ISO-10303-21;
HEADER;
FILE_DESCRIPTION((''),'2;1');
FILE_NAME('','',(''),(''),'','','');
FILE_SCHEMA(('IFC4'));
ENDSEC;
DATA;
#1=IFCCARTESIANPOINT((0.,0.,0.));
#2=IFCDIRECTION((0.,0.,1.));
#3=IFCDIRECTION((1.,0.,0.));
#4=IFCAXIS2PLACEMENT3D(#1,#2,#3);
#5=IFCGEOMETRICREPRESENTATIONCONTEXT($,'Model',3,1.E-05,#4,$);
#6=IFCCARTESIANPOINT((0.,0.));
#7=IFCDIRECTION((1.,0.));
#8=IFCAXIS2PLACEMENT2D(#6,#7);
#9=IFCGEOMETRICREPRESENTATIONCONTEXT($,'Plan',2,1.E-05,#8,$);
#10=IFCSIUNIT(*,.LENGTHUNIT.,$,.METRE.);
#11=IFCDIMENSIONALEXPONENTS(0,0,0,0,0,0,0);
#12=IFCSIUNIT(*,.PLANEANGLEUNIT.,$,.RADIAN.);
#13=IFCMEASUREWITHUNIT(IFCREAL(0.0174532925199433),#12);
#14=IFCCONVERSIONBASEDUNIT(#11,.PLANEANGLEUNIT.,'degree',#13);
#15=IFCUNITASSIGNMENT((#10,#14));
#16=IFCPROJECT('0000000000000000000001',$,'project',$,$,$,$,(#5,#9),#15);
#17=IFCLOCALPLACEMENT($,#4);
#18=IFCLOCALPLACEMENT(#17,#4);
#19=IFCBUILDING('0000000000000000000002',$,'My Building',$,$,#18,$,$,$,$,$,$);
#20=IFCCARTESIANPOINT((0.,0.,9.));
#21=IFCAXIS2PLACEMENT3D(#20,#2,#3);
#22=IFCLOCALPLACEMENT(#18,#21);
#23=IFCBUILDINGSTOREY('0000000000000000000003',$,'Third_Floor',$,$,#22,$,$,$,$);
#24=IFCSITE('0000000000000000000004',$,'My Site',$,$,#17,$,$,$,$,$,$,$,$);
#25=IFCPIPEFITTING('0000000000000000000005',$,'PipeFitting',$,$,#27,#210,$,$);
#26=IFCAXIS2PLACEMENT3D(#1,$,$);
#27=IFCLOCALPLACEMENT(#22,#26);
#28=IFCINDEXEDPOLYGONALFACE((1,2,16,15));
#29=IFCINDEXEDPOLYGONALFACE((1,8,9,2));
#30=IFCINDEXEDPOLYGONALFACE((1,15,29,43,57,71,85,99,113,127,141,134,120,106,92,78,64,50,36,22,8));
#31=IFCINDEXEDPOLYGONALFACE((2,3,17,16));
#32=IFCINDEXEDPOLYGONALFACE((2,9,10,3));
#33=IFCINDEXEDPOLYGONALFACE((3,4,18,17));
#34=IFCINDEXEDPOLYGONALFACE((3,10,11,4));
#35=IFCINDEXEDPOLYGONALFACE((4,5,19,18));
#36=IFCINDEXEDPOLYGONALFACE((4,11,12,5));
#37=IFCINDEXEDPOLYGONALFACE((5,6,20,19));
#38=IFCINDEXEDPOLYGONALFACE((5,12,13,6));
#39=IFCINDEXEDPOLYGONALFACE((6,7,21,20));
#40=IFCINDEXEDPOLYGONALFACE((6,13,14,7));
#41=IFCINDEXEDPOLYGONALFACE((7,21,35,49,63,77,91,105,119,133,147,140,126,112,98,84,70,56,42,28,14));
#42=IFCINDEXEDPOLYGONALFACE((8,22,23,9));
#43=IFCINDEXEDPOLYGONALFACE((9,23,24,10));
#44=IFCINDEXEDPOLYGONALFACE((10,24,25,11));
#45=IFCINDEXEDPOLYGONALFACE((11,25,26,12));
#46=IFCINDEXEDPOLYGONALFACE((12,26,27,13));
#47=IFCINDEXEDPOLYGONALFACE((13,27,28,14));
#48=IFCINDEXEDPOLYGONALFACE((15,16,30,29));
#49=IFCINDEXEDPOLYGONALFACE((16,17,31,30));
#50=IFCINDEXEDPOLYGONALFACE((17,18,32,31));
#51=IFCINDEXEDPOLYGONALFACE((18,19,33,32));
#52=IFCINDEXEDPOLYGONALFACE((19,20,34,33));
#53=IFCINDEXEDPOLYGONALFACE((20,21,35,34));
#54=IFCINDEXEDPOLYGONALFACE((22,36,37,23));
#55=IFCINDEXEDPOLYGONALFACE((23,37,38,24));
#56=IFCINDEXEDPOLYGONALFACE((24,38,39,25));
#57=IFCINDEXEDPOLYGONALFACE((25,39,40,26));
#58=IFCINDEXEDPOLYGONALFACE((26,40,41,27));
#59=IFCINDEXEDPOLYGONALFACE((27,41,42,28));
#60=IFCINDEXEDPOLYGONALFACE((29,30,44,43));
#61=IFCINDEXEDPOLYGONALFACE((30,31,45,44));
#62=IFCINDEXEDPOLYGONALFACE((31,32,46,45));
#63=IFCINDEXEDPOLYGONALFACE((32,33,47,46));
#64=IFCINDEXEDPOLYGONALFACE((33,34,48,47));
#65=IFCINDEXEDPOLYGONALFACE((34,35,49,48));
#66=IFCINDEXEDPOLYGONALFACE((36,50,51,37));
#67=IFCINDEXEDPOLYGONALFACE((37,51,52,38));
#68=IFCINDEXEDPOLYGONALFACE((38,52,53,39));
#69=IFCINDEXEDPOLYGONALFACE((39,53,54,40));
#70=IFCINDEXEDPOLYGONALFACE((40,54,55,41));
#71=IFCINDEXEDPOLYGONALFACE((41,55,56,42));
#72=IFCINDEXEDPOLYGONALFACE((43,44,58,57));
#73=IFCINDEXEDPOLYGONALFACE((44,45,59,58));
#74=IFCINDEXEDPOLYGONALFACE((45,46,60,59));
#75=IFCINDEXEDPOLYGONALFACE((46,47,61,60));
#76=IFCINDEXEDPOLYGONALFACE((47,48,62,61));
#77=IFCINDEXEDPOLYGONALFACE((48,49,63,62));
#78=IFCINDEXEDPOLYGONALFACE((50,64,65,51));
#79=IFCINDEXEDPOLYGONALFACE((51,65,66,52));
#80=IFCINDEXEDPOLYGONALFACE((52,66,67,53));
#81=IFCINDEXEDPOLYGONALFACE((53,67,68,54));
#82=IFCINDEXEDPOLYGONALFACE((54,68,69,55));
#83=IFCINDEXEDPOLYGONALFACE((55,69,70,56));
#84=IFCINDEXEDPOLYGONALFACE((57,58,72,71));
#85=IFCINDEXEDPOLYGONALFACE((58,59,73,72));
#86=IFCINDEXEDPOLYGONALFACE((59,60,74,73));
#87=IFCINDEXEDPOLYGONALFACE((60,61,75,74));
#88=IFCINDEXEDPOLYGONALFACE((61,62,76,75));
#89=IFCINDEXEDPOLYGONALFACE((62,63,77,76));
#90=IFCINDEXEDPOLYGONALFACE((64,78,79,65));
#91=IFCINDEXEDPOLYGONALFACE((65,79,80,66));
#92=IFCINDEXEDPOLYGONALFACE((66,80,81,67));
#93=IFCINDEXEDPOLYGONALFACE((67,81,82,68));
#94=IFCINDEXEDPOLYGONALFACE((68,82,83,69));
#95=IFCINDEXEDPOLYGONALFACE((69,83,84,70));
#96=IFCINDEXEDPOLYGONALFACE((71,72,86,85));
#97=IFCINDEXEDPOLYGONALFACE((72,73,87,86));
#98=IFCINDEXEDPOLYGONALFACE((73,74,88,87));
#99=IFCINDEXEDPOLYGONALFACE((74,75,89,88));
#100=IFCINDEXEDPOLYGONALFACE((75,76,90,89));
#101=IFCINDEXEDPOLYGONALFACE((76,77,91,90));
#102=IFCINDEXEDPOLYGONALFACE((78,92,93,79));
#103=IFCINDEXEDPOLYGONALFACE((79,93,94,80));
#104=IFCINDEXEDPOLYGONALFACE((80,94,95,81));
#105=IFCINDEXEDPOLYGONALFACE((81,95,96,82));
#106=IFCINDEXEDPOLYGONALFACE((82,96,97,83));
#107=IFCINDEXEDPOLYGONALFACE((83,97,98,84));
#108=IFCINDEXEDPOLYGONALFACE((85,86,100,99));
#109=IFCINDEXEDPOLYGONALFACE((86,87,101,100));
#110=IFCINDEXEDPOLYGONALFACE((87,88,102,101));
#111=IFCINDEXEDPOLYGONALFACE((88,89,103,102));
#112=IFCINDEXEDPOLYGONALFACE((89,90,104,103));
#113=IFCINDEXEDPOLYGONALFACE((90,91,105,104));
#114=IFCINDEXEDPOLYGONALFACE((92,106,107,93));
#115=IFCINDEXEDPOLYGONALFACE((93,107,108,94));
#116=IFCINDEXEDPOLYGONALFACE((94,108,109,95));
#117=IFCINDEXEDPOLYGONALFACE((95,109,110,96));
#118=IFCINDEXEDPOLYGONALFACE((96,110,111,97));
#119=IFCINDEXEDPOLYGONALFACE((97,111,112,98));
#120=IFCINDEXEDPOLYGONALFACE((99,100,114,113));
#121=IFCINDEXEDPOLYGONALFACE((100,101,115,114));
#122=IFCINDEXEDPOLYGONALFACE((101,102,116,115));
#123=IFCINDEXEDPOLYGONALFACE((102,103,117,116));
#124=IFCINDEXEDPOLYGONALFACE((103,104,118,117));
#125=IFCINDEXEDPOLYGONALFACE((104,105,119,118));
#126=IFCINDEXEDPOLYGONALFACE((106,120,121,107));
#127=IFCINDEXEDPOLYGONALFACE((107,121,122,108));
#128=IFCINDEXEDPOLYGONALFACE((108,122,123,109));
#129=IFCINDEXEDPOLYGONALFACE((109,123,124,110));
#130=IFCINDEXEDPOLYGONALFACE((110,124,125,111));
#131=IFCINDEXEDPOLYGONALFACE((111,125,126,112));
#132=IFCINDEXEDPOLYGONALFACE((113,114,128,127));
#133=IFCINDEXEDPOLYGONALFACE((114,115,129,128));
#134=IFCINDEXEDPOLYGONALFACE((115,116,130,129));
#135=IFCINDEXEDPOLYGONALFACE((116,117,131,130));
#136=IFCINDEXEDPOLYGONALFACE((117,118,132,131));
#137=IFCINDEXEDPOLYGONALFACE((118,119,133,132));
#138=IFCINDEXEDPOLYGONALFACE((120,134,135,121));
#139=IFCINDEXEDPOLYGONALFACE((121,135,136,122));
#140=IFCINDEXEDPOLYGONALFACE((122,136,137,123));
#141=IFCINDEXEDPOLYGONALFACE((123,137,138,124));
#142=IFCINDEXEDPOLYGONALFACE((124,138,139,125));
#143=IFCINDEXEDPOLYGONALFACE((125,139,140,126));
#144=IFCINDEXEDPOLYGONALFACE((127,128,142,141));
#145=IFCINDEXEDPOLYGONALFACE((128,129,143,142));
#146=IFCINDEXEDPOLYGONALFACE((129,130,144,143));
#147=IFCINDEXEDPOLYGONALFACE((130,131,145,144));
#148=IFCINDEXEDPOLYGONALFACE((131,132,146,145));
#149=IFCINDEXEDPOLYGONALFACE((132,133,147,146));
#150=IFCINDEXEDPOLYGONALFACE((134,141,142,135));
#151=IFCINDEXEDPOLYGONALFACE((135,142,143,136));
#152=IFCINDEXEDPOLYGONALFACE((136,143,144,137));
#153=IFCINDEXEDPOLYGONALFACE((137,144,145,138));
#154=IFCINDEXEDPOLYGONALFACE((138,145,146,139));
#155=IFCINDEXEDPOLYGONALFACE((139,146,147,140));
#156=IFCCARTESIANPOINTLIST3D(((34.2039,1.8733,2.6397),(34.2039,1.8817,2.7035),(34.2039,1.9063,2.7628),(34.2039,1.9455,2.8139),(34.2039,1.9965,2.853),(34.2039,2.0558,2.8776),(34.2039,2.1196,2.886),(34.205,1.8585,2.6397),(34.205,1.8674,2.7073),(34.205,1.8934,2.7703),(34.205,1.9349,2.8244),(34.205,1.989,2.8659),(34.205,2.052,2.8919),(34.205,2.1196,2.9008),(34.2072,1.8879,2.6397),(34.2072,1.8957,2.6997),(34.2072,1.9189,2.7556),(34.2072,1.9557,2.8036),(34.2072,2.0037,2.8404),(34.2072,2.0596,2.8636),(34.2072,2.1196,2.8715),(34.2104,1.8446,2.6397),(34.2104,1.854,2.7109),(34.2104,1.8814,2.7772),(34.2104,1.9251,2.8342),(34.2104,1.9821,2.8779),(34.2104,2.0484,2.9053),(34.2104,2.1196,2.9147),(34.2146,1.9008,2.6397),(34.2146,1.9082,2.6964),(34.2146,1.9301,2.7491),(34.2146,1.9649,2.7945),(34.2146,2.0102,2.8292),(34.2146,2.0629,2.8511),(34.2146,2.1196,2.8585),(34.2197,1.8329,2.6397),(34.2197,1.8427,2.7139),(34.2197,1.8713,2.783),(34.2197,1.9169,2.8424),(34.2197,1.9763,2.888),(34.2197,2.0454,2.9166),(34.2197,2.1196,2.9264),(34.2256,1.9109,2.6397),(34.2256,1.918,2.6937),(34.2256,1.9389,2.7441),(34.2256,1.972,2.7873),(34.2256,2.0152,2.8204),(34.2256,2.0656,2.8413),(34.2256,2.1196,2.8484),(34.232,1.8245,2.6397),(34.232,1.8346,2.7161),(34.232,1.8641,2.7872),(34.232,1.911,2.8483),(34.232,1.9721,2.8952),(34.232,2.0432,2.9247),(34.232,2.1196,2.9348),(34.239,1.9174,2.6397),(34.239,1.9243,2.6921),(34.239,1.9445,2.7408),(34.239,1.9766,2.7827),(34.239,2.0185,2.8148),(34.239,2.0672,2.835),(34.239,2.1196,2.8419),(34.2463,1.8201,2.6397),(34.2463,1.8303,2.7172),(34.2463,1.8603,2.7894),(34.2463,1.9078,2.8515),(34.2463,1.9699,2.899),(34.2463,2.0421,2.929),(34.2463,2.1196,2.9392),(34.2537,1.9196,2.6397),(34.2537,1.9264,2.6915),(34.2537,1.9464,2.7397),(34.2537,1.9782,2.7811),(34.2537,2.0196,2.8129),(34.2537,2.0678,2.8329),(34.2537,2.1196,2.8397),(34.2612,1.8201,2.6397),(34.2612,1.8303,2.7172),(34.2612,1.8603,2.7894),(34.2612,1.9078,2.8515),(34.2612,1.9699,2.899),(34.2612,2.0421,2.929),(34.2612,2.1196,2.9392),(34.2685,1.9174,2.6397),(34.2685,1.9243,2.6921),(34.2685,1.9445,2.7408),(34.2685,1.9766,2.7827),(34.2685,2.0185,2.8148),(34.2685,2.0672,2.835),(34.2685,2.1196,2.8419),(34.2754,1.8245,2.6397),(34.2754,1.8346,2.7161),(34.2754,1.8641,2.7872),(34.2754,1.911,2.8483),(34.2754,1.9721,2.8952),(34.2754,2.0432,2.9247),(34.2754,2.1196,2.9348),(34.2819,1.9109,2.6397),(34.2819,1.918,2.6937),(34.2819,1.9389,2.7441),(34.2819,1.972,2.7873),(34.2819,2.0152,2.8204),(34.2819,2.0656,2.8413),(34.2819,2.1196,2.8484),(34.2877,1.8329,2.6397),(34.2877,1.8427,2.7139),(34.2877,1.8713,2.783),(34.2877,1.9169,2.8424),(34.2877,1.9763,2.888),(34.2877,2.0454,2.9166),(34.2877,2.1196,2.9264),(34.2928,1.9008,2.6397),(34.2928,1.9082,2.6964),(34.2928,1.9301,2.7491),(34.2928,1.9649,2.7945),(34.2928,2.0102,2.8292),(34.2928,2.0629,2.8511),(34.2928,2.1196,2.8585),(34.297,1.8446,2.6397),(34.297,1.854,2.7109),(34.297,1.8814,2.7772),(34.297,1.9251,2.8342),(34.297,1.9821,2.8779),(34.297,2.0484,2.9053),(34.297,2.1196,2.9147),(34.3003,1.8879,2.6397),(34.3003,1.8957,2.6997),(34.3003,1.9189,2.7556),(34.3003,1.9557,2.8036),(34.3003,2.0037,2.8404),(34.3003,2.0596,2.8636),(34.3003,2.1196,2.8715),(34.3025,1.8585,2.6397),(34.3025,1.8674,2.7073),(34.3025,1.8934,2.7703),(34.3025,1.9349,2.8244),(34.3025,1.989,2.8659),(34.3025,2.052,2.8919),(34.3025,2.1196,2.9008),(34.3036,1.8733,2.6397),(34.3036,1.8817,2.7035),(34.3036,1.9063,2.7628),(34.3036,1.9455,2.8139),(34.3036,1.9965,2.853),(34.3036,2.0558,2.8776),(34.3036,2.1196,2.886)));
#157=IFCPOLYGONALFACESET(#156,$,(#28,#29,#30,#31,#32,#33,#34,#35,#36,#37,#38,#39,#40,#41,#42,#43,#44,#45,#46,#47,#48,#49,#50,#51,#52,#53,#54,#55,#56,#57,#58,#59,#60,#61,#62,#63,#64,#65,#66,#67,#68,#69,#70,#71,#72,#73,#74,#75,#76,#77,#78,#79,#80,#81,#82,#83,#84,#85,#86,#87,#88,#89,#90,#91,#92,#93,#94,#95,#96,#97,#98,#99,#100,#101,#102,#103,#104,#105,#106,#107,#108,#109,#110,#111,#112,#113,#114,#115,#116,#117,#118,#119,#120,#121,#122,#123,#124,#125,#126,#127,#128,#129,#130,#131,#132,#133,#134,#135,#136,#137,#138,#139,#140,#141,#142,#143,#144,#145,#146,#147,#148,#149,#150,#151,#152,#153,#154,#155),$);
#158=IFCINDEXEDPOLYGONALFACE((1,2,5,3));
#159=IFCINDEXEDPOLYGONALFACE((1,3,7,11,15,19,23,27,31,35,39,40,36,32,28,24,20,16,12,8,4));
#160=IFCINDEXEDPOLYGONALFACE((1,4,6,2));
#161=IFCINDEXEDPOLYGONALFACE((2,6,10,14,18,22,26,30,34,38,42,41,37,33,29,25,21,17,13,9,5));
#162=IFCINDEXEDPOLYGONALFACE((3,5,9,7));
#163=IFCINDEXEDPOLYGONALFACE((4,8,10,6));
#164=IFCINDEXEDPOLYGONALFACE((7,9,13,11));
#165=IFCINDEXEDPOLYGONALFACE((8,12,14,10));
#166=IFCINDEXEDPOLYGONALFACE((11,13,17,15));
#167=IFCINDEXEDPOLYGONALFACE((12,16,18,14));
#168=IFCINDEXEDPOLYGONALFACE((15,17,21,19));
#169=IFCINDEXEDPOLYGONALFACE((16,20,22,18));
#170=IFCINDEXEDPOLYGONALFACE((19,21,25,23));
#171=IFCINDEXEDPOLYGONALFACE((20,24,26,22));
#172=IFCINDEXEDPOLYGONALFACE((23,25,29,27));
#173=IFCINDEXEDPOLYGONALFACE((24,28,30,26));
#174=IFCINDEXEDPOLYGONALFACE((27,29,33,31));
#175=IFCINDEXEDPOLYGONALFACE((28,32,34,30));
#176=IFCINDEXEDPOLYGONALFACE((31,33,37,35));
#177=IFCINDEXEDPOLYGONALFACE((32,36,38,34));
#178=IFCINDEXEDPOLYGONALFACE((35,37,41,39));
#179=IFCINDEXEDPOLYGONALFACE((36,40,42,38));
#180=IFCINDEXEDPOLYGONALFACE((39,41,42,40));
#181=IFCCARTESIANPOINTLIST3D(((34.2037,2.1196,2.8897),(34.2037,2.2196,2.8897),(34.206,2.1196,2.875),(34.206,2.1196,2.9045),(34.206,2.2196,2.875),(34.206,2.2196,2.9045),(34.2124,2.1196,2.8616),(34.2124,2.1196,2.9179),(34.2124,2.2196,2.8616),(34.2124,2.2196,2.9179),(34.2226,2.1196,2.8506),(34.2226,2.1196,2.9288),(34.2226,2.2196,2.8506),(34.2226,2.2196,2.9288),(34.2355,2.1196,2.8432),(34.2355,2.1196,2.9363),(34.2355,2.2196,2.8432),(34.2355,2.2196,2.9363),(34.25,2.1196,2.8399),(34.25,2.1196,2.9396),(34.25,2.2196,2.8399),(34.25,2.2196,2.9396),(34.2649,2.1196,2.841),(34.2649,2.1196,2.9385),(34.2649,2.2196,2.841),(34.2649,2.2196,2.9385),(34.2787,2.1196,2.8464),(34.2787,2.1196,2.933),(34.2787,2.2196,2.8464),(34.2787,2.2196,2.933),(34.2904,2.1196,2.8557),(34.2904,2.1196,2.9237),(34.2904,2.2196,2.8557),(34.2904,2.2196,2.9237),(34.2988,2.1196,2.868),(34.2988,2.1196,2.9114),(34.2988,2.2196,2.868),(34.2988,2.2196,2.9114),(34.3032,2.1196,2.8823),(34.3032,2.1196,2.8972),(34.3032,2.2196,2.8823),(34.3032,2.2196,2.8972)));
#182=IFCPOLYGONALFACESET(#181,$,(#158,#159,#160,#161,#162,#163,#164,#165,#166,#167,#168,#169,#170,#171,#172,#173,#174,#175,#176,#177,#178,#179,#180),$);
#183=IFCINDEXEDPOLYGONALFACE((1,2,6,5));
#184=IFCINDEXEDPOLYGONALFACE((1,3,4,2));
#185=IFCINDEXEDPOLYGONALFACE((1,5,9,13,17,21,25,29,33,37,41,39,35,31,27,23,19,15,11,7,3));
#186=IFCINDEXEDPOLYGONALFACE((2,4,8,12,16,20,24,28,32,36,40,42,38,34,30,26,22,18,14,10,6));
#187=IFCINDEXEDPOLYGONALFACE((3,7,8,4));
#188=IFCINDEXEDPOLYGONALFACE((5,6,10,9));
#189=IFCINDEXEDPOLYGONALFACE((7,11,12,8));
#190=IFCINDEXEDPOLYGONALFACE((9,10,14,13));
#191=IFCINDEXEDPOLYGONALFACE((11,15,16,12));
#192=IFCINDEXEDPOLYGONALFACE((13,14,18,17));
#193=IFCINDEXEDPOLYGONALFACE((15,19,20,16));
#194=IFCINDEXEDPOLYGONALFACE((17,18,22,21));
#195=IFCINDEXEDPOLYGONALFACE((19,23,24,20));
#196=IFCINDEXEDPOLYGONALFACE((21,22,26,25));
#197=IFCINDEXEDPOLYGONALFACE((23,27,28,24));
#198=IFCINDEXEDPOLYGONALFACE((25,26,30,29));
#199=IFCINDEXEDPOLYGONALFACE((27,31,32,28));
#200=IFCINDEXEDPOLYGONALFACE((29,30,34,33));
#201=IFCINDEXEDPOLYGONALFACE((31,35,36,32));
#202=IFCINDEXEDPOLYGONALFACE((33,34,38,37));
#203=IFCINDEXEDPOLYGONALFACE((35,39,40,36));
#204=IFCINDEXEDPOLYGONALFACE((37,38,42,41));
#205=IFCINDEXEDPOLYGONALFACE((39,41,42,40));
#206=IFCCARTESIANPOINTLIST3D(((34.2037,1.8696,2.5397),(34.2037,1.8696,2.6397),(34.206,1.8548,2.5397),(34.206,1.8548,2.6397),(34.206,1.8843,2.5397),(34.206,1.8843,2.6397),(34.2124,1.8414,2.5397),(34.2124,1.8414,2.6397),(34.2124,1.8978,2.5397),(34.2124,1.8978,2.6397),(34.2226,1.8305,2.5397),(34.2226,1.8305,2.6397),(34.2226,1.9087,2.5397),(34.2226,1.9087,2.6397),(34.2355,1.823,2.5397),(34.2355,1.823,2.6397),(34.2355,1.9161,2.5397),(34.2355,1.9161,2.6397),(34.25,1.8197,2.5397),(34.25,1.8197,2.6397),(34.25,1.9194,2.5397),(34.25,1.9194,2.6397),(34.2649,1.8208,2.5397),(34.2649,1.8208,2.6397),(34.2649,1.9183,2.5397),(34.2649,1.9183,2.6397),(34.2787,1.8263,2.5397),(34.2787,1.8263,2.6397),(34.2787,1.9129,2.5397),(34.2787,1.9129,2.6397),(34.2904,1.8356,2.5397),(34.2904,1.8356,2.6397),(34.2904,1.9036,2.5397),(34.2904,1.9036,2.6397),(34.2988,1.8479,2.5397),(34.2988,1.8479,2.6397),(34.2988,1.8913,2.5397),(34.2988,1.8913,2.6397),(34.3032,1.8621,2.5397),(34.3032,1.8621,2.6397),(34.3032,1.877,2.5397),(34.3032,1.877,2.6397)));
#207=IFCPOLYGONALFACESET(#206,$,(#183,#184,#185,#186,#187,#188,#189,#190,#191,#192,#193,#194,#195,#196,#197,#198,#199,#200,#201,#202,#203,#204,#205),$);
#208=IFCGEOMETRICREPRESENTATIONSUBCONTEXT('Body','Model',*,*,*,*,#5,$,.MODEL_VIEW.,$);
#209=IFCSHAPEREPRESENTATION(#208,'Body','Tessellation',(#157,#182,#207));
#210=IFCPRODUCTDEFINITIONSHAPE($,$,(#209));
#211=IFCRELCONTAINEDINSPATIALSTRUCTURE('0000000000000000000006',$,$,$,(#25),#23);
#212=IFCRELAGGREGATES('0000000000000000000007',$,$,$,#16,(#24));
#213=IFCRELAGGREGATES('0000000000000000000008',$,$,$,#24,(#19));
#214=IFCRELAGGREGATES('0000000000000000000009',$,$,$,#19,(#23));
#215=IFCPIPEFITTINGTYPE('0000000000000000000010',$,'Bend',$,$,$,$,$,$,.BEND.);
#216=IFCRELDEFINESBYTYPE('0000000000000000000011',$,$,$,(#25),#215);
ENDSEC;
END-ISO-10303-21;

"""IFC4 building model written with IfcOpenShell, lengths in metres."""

from ifc_helpers import new_model, entity, si_unit, converted_unit, frame, origin_with_axes, origin_2d_with_axis, place, context, subcontext, project, spatial, circle, extrude, source, transform, mapped, type_object, type_shapes, element, save


model = new_model("IFC4")

# Units and contexts
model_context = context("Model", 3, precision=1e-05, world=origin_with_axes())
plan_context = context("Plan", 2, precision=1e-05, world=origin_2d_with_axis())
body_context_1 = subcontext(model_context, "Body", "Model", "MODEL_VIEW")
ifc_project = project(units=[si_unit("LENGTHUNIT", "METRE"), converted_unit("PLANEANGLEUNIT", "degree", entity("IfcReal", 0.0174532925199433), si_unit("PLANEANGLEUNIT", "RADIAN"), dimensions=[0, 0, 0, 0, 0, 0, 0])], contexts=[model_context, plan_context])

# Site, building, storey
site_placement = place(None, origin_with_axes())
site = spatial("IfcSite", under=ifc_project, at=site_placement, Name="My Site")
building_placement = place(site_placement, origin_with_axes())
building = spatial("IfcBuilding", under=site, at=building_placement, Name="My Building")
storey_placement = place(building_placement, frame((0.0, 0.0, 9.0), z_axis=(0.0, 0.0, 1.0), x_axis=(1.0, 0.0, 0.0)))
storey = spatial("IfcBuildingStorey", under=building, at=storey_placement, Name="Third_Floor")

# Pipe fitting
pipe_fitting_type = type_object("IfcPipeFittingType", Name="Bend", PredefinedType="BEND")
shared_shape_1 = source(origin_with_axes(), body_context_1, "Body", "SolidModel", [
    entity("IfcSweptDiskSolid", entity("IfcIndexedPolyCurve", entity("IfcCartesianPointList3D", [[0.0, 0.0, -0.1], [0.0, -0.0732, -0.2768], [0.0, -0.25, -0.35]]), [entity("IfcArcIndex", [1, 2, 3])]), 0.05),
    extrude(circle(Radius=0.05), origin_with_axes(), (0.0, 0.0, -1.0), 0.1),
    extrude(circle(Radius=0.05), frame((0.0, -0.25, -0.35), z_axis=(0.0, -1.0, 0.0), x_axis=(1.0, 0.0, 0.0)), (0.0, 0.0, 1.0), 0.1),
])
type_shapes(pipe_fitting_type, [shared_shape_1])
for number, where, z_axis, x_axis, name in (
    (1, (34.2537, 2.2196, 2.8897), (0.0, 1.0, 0.0), (-1.0, 0.0, 0.0), "PipeFitting"),
):
    element("IfcPipeFitting", number, at=place(storey_placement, frame(where, z_axis=z_axis, x_axis=x_axis)), inside=storey, type_object=pipe_fitting_type, Name=name, context=body_context_1, shape_type="MappedRepresentation", body=[
        mapped(shared_shape_1, transform((0.0, 0.0, 0.0), x_axis=(1.0, 0.0, 0.0), y_axis=(0.0, 1.0, 0.0), z_axis=(0.0, 0.0, 1.0), scale=1.0)),
    ])

save(model, "model.ifc")
